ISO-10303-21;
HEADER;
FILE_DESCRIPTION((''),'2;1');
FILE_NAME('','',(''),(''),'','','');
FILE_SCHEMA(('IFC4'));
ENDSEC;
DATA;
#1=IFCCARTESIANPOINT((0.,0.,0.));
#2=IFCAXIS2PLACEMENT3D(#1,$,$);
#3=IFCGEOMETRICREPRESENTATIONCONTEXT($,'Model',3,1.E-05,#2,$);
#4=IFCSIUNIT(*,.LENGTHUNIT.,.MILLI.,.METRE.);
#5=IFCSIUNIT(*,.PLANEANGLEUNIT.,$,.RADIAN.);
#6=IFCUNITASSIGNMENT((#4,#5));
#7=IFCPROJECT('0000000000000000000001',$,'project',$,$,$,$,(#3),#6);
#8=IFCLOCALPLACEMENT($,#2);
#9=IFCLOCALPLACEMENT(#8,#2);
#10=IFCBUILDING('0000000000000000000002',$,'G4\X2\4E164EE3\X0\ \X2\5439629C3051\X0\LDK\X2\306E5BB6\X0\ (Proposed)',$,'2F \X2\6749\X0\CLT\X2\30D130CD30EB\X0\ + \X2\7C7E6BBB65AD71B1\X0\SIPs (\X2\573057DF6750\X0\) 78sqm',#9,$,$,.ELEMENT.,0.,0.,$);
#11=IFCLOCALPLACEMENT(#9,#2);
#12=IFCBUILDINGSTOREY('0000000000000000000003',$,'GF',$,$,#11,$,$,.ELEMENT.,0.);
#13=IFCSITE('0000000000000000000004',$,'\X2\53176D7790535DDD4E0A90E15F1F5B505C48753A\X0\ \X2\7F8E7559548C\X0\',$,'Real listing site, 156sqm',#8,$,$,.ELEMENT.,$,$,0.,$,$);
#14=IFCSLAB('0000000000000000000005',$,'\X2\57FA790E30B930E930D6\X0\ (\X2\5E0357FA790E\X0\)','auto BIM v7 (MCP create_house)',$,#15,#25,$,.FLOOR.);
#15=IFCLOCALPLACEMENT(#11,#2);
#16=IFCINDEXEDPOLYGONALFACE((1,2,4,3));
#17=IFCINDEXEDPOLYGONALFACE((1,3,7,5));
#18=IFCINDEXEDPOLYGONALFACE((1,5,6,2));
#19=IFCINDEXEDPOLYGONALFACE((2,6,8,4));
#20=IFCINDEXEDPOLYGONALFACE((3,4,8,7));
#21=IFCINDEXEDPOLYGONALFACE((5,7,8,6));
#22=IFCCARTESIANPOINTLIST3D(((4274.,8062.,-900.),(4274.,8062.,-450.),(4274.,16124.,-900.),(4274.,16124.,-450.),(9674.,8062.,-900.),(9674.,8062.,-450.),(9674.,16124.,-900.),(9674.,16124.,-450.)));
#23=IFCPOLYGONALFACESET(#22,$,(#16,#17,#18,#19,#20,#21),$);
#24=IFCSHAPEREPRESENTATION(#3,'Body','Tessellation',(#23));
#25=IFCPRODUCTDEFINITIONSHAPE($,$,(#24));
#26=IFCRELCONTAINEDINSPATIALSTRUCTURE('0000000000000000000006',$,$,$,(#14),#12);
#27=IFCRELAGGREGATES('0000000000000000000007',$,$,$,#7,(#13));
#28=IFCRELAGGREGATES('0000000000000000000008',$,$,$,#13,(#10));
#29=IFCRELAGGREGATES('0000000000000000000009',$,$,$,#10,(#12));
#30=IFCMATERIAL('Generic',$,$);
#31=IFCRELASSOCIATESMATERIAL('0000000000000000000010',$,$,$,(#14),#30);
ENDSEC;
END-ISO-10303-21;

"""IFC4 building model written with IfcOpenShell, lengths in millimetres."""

from ifc_helpers import new_model, si_unit, frame, frame_2d, origin, place, context, project, spatial, rectangle, extrude, material, element, save


model = new_model("IFC4")

# Units and contexts
model_context = context("Model", 3, precision=1e-05, world=origin())
ifc_project = project(units=[si_unit("LENGTHUNIT", "METRE", prefix="MILLI"), si_unit("PLANEANGLEUNIT", "RADIAN")], contexts=[model_context])

# Site, building, storey
site_placement = place(None, origin())
site = spatial("IfcSite", under=ifc_project, at=site_placement, Name="北海道川上郡弟子屈町 美留和", ObjectType="Real listing site, 156sqm", CompositionType="ELEMENT", RefElevation=0.0)
building_placement = place(site_placement, origin())
building = spatial("IfcBuilding", under=site, at=building_placement, Name="G4世代 吹抜けLDKの家 (Proposed)", ObjectType="2F 杉CLTパネル + 籾殻断熱SIPs (地域材) 78sqm", CompositionType="ELEMENT", ElevationOfRefHeight=0.0, ElevationOfTerrain=0.0)
storey_placement = place(building_placement, origin())
storey = spatial("IfcBuildingStorey", under=building, at=storey_placement, Name="GF", CompositionType="ELEMENT", Elevation=0.0)

# Slab
ifc_material = material(Name="Generic")
slab_1_placement = place(storey_placement, frame((2137.0, 4031.0, -450.0)))
element("IfcSlab", 1, at=slab_1_placement, inside=storey, material=ifc_material, Name="基礎スラブ (布基礎)", Description="auto BIM v7 (MCP create_house)", PredefinedType="FLOOR", context=model_context, shape_type="SweptSolid", body=[
    extrude(rectangle(XDim=5400.0, YDim=8062.0, at=frame_2d((2700.0, 4031.0))), frame((2137.0, 4031.0, -450.0)), (0.0, 0.0, 1.0), 450.0),
])

save(model, "model.ifc")
